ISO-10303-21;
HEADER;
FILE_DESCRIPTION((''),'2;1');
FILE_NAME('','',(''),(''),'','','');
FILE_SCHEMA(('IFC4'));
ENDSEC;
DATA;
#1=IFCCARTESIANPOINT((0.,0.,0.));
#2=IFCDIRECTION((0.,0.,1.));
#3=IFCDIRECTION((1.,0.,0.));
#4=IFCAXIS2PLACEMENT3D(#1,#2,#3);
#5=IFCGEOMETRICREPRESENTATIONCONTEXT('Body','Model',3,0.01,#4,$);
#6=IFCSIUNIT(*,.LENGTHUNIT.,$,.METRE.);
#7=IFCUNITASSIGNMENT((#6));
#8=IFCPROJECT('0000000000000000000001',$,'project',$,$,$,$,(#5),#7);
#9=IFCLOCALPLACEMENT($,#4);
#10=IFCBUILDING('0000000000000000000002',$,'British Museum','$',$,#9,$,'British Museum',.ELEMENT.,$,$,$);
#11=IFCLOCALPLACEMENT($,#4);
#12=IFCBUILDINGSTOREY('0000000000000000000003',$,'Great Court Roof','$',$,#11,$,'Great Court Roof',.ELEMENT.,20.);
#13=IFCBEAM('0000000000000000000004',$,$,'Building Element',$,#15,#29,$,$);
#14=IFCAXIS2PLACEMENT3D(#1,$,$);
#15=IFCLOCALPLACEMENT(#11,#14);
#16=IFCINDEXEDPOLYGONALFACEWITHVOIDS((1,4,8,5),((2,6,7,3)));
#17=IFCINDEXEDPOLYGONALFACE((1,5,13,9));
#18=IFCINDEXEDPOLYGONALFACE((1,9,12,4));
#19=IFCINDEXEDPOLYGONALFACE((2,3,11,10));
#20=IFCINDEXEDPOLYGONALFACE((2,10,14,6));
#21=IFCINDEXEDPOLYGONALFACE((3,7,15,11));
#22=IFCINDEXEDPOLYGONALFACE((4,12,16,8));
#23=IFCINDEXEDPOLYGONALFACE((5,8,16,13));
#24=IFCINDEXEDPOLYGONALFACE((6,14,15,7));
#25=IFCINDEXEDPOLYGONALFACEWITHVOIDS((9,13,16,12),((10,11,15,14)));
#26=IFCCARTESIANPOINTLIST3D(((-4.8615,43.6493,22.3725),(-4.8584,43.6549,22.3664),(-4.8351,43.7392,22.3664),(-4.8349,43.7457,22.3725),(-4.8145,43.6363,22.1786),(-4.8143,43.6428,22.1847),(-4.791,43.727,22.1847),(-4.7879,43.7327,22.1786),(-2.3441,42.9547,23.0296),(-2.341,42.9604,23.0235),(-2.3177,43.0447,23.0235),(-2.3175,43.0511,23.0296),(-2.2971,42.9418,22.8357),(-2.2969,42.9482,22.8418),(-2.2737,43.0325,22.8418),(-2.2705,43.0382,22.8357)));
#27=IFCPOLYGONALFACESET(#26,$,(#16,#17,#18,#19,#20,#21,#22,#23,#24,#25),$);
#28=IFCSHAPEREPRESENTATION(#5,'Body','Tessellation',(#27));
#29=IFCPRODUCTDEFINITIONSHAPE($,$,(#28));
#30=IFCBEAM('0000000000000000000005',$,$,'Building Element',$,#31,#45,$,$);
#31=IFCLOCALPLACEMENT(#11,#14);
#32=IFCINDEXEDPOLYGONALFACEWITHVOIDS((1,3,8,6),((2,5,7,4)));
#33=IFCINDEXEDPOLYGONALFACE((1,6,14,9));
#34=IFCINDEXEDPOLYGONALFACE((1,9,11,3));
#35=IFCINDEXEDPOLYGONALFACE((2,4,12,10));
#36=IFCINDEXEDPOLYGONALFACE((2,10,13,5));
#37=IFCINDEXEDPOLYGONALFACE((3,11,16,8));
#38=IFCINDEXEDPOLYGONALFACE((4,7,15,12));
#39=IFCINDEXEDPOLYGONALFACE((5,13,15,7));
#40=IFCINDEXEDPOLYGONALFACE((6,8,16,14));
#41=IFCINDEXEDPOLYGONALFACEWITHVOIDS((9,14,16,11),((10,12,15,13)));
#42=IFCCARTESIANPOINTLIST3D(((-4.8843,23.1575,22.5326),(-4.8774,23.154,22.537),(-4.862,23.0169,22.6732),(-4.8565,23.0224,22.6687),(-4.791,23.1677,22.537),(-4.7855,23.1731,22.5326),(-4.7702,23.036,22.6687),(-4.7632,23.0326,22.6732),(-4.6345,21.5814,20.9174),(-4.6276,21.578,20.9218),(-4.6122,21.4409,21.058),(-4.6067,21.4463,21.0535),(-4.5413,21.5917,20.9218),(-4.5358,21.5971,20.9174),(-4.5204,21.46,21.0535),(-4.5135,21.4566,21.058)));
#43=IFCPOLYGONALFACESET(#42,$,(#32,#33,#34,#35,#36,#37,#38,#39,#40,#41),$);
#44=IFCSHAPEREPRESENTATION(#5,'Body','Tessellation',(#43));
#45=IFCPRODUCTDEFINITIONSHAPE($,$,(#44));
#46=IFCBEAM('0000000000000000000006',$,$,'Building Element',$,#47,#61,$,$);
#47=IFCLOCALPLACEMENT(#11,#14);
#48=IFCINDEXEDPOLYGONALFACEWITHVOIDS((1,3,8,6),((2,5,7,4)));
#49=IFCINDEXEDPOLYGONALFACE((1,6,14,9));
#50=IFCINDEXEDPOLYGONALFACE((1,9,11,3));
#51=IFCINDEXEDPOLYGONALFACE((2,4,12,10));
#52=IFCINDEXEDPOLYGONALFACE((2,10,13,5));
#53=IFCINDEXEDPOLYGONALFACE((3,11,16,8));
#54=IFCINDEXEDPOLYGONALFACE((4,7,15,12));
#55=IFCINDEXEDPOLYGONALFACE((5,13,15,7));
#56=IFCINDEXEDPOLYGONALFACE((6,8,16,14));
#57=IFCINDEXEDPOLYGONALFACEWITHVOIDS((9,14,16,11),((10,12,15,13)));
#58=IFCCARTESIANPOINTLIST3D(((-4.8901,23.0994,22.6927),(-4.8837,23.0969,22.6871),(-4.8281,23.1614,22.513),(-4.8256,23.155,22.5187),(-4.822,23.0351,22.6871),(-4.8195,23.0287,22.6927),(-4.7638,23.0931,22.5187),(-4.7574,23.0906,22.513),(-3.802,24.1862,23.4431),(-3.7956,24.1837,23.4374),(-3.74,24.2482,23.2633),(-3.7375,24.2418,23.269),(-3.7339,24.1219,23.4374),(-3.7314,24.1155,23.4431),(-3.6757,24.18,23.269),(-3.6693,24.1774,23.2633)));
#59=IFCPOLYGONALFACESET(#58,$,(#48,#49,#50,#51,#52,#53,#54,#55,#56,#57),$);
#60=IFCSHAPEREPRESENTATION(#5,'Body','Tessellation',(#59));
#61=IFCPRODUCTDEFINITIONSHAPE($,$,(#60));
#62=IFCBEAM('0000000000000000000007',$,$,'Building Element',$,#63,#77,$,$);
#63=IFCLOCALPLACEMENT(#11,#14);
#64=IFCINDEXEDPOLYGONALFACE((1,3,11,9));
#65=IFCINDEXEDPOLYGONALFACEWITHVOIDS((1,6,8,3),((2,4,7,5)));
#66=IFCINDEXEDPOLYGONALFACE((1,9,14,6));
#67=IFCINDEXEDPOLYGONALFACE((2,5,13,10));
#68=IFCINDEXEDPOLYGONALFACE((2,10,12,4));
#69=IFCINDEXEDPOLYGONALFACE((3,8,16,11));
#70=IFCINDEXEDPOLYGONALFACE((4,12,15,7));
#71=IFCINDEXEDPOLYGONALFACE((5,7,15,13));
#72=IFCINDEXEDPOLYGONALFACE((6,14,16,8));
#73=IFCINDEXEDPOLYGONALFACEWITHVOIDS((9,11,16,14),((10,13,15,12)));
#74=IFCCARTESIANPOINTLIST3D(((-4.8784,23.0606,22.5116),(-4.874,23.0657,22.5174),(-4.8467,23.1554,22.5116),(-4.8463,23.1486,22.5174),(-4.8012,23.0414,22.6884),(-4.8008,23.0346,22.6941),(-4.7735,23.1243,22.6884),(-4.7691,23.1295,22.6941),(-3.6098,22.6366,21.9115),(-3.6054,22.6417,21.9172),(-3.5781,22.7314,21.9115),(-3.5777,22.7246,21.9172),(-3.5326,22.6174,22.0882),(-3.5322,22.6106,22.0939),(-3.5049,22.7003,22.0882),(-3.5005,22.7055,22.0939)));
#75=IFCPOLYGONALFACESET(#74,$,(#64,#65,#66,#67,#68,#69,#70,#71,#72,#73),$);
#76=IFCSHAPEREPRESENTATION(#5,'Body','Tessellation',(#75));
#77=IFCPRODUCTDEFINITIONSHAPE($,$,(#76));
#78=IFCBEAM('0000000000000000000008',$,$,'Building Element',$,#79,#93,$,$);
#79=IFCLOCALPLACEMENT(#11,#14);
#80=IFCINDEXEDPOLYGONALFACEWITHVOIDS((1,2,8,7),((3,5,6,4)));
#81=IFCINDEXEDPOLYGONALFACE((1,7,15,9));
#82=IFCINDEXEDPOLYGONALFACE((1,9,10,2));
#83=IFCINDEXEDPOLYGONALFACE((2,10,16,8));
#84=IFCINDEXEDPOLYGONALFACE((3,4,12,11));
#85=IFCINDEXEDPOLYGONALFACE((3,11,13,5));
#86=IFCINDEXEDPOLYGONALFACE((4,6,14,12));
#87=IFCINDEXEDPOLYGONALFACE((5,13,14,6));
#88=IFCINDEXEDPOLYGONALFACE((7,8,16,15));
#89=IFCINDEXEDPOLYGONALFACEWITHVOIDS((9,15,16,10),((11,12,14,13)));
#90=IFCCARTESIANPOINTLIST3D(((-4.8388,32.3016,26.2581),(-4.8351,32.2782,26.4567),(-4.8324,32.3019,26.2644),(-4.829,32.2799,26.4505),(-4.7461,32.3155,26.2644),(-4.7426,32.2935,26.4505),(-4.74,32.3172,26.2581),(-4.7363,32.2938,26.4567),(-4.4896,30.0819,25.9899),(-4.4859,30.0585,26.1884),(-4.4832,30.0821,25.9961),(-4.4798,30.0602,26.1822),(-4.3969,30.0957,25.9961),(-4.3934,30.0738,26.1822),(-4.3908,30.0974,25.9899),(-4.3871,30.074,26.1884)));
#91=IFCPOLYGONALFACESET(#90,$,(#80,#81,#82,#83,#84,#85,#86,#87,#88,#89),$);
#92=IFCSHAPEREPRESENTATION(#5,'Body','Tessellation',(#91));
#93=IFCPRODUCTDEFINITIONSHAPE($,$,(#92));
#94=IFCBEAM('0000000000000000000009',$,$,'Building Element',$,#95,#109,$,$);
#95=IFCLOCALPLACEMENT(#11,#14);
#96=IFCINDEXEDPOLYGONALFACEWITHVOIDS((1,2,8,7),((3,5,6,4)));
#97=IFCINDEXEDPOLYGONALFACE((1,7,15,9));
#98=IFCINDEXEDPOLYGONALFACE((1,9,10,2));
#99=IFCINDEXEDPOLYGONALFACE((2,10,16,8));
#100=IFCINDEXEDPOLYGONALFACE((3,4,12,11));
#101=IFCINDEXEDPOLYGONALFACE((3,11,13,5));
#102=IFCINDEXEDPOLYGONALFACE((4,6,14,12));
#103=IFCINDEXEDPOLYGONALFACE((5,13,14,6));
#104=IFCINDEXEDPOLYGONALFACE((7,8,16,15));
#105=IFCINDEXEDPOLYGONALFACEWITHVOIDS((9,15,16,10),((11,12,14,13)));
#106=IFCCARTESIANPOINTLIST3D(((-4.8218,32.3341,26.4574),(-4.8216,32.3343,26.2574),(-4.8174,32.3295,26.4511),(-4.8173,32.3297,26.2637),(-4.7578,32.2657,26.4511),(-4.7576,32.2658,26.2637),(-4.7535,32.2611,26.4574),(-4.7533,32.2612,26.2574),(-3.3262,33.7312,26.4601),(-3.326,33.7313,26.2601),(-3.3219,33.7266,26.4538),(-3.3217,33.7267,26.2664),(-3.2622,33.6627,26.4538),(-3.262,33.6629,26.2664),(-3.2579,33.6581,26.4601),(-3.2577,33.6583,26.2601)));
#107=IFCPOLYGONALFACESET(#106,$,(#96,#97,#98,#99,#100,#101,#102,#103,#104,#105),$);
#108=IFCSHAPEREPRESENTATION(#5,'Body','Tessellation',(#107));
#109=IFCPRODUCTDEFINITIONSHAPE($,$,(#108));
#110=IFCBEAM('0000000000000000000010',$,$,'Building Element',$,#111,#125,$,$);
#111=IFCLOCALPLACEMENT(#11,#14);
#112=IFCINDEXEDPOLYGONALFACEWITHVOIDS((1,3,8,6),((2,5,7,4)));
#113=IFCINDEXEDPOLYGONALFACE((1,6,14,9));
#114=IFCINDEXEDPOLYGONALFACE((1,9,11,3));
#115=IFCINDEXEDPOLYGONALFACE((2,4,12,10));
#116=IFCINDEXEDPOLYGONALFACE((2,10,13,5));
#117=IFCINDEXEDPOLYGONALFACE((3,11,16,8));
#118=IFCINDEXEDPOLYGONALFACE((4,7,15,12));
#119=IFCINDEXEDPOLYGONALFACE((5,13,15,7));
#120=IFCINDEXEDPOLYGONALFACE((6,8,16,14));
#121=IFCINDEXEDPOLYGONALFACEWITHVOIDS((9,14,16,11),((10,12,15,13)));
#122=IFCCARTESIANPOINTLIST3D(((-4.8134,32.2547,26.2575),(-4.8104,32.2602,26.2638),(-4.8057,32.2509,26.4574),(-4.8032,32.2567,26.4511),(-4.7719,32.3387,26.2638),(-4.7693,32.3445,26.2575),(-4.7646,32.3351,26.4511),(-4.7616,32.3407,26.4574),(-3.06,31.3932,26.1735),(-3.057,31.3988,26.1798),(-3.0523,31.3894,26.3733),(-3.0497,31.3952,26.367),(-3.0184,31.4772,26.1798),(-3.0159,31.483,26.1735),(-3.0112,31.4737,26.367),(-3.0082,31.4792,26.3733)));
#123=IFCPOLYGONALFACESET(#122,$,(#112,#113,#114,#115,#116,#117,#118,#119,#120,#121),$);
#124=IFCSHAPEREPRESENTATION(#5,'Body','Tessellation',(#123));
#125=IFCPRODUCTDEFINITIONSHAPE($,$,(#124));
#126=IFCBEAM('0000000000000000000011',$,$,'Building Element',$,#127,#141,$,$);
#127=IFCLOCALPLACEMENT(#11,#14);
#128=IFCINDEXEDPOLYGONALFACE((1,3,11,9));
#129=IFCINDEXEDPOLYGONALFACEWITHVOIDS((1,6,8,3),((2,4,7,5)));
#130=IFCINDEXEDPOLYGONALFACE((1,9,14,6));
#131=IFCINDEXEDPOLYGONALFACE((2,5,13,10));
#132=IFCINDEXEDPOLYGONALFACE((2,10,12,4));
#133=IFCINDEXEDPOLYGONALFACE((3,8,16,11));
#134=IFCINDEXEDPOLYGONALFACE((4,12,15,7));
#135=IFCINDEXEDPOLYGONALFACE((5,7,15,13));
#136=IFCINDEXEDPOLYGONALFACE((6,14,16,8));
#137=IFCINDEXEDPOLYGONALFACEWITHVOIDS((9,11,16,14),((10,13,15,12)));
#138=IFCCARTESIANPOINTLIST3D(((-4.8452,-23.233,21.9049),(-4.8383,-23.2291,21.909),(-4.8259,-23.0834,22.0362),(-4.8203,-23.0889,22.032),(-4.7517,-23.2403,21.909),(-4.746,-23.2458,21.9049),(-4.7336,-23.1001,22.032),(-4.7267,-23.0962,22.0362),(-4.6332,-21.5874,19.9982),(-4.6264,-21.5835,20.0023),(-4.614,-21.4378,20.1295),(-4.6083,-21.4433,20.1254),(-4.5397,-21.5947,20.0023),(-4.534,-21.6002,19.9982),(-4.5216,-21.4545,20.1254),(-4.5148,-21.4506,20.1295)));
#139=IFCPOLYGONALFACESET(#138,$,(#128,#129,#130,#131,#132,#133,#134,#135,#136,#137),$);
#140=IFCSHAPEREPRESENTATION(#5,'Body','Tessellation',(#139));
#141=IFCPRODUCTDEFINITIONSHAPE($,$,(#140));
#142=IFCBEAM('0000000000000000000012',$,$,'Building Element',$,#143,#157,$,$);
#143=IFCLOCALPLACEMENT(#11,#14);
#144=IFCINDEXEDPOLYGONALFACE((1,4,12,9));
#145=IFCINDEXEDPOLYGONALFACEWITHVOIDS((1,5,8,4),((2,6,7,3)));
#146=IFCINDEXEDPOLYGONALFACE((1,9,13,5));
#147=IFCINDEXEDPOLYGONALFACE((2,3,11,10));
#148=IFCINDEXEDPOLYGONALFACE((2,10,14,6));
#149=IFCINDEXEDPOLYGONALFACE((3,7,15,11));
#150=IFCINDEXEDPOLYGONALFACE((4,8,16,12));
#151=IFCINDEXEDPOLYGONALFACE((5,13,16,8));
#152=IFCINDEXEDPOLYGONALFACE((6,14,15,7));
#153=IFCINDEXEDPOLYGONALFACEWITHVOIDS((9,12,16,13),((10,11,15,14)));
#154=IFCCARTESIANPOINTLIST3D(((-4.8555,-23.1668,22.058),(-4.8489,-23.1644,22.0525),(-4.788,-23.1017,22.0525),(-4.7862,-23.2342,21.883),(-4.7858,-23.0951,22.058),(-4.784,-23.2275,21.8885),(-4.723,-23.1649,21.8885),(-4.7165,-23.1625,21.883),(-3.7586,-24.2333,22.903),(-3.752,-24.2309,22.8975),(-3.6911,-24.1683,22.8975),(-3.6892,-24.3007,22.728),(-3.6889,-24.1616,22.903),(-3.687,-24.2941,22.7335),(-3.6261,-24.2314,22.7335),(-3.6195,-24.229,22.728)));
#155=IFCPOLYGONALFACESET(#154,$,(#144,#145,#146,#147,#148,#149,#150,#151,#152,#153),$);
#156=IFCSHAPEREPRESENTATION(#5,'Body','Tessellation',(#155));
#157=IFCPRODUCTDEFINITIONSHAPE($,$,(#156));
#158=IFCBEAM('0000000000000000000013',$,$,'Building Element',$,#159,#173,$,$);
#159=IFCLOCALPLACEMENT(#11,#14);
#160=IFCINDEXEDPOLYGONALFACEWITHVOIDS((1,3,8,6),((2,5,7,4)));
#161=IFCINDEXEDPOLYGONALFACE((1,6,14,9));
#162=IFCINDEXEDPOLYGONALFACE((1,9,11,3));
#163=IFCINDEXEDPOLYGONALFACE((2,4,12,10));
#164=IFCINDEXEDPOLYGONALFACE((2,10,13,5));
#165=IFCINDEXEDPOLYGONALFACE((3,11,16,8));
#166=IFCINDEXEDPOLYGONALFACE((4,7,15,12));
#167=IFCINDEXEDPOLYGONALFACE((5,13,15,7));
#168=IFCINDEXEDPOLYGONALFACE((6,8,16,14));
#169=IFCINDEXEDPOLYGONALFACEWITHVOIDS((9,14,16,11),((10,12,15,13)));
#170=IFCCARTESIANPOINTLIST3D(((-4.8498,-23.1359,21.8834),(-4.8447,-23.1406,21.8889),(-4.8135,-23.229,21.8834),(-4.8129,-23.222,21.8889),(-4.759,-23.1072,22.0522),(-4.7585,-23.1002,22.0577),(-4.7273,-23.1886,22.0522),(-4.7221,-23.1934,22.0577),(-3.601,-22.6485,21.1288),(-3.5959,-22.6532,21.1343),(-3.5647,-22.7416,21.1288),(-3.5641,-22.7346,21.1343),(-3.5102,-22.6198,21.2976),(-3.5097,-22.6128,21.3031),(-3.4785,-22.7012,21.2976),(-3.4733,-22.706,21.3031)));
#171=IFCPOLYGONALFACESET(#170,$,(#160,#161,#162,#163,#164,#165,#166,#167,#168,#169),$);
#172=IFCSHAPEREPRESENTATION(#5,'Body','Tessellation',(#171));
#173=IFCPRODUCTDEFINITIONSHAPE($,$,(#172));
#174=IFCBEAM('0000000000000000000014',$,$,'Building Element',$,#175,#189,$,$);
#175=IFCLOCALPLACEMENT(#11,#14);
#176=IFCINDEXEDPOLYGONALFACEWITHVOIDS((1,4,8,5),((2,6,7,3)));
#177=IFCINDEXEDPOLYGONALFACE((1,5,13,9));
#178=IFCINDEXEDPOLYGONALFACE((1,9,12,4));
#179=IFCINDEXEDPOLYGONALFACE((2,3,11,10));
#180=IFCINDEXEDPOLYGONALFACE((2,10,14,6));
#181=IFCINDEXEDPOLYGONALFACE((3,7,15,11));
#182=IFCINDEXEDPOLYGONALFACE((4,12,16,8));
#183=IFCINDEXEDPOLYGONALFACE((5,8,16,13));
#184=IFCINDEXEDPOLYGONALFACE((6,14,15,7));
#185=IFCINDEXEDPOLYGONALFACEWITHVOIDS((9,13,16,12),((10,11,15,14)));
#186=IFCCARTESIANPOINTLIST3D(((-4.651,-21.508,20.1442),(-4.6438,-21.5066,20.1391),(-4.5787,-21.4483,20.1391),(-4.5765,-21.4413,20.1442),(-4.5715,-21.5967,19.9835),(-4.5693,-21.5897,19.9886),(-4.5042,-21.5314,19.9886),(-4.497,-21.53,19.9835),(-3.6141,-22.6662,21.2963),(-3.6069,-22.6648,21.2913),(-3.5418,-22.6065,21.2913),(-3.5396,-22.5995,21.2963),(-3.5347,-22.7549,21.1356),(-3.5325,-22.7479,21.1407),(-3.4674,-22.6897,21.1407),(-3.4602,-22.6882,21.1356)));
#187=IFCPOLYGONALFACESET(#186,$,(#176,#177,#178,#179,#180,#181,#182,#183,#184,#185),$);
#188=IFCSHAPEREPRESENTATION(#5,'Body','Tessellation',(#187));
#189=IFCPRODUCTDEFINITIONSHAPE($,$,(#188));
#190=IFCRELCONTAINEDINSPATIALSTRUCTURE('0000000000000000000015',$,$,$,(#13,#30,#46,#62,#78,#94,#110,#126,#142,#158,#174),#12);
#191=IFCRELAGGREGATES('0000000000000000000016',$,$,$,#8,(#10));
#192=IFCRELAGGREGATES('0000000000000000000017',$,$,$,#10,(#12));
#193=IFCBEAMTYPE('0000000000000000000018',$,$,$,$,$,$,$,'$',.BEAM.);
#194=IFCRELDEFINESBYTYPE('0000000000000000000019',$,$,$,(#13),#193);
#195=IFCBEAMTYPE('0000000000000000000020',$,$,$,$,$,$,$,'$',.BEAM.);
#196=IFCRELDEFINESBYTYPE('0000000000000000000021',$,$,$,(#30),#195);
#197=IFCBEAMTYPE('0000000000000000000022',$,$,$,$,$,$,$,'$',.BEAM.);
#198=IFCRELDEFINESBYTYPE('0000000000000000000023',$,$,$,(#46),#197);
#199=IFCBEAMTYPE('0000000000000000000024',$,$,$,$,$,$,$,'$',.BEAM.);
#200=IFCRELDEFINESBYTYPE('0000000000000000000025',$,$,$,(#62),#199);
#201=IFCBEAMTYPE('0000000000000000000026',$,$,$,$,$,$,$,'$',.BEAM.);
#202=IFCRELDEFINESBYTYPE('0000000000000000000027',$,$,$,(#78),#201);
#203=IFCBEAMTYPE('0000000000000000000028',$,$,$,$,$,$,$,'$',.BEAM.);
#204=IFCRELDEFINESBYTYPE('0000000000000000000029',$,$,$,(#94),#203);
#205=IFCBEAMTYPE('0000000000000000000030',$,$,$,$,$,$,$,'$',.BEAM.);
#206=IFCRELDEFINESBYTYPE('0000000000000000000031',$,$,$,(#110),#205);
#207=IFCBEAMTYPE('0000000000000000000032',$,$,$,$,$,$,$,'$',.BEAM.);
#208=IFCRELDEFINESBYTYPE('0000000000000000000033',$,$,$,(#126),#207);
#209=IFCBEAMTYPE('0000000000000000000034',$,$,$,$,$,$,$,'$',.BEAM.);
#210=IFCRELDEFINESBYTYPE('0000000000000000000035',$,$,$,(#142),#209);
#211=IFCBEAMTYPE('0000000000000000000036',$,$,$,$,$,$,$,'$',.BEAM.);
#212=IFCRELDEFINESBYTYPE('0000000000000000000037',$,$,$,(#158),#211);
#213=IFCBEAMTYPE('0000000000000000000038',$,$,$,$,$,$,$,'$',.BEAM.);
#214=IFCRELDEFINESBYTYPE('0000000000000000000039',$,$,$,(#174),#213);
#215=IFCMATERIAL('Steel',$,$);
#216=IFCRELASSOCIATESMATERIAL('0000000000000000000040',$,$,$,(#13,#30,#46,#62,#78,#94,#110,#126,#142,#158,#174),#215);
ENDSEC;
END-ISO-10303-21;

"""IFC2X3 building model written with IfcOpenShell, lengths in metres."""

from ifc_helpers import new_model, si_unit, frame, origin_with_axes, origin_2d, place, context, project, spatial, hollow_rectangle, extrude, material, type_object, element, save


model = new_model("IFC2X3")

# Units and contexts
model_context = context("Model", 3, precision=0.01, world=origin_with_axes(), identifier="Body")
ifc_project = project(units=[si_unit("LENGTHUNIT", "METRE")], contexts=[model_context])

# Building, storey
building_placement = place(None, origin_with_axes())
building = spatial("IfcBuilding", under=ifc_project, at=building_placement, Name="British Museum", Description="$", LongName="British Museum", CompositionType="ELEMENT")
storey_placement = place(None, origin_with_axes())
storey = spatial("IfcBuildingStorey", under=building, at=storey_placement, Name="Great Court Roof", Description="$", LongName="Great Court Roof", CompositionType="ELEMENT", Elevation=20.0)

# Beams
ifc_material = material(Name="Steel")
beam_type_1 = type_object("IfcBeamType", ElementType="$", PredefinedType="BEAM")
beam_1_placement = place(None, origin_with_axes())
element("IfcBeam", 1, at=beam_1_placement, inside=storey, type_object=beam_type_1, material=ifc_material, Description="Building Element", context=model_context, shape_type="SweptSolid", body=[
    extrude(hollow_rectangle(XDim=0.1, YDim=0.2, WallThickness=0.0063, InnerFilletRadius=-0.0063, OuterFilletRadius=0.0, at=origin_2d()), frame((-4.8247, 43.691, 22.2755), z_axis=(0.934845, -0.257913, 0.244021), x_axis=(0.265953, 0.963986, 0.0)), (0.0, 0.0, 1.0), 2.6928),
])
beam_type_2 = type_object("IfcBeamType", ElementType="$", PredefinedType="BEAM")
beam_2_placement = place(None, origin_with_axes())
element("IfcBeam", 2, at=beam_2_placement, inside=storey, type_object=beam_type_2, material=ifc_material, Description="Building Element", context=model_context, shape_type="SweptSolid", body=[
    extrude(hollow_rectangle(XDim=0.1, YDim=0.2, WallThickness=0.0063, InnerFilletRadius=-0.0063, OuterFilletRadius=0.0, at=origin_2d()), frame((-4.8238, 23.095, 22.6029), z_axis=(0.110005, -0.694141, -0.711384), x_axis=(0.987674, 0.156523, 0.0)), (0.0, 0.0, 1.0), 2.2705),
])
beam_type_3 = type_object("IfcBeamType", ElementType="$", PredefinedType="BEAM")
beam_3_placement = place(None, origin_with_axes())
element("IfcBeam", 3, at=beam_3_placement, inside=storey, type_object=beam_type_3, material=ifc_material, Description="Building Element", context=model_context, shape_type="SweptSolid", body=[
    extrude(hollow_rectangle(XDim=0.1, YDim=0.2, WallThickness=0.0063, InnerFilletRadius=-0.0063, OuterFilletRadius=0.0, at=origin_2d()), frame((-4.8238, 23.095, 22.6029), z_axis=(0.635872, 0.635132, 0.438491), x_axis=(-0.706695, 0.707519, 0.0)), (0.0, 0.0, 1.0), 1.7112),
])
beam_type_4 = type_object("IfcBeamType", ElementType="$", PredefinedType="BEAM")
beam_4_placement = place(None, origin_with_axes())
element("IfcBeam", 4, at=beam_4_placement, inside=storey, type_object=beam_type_4, material=ifc_material, Description="Building Element", context=model_context, shape_type="SweptSolid", body=[
    extrude(hollow_rectangle(XDim=0.1, YDim=0.2, WallThickness=0.0063, InnerFilletRadius=-0.0063, OuterFilletRadius=0.0, at=origin_2d()), frame((-4.8238, 23.095, 22.6029), z_axis=(0.86531, -0.289209, -0.409386), x_axis=(0.316989, 0.948429, 0.0)), (0.0, 0.0, 1.0), 1.4661),
])
beam_type_5 = type_object("IfcBeamType", ElementType="$", PredefinedType="BEAM")
beam_5_placement = place(None, origin_with_axes())
element("IfcBeam", 5, at=beam_5_placement, inside=storey, type_object=beam_type_5, material=ifc_material, Description="Building Element", context=model_context, shape_type="SweptSolid", body=[
    extrude(hollow_rectangle(XDim=0.1, YDim=0.2, WallThickness=0.0063, InnerFilletRadius=-0.0063, OuterFilletRadius=0.0, at=origin_2d()), frame((-4.7875, 32.2977, 26.3574), z_axis=(0.154304, -0.980885, -0.118556), x_axis=(0.987852, 0.1554, 0.0)), (0.0, 0.0, 1.0), 2.263),
])
beam_type_6 = type_object("IfcBeamType", ElementType="$", PredefinedType="BEAM")
beam_6_placement = place(None, origin_with_axes())
element("IfcBeam", 6, at=beam_6_placement, inside=storey, type_object=beam_type_6, material=ifc_material, Description="Building Element", context=model_context, shape_type="SweptSolid", body=[
    extrude(hollow_rectangle(XDim=0.1, YDim=0.2, WallThickness=0.0063, InnerFilletRadius=-0.0063, OuterFilletRadius=0.0, at=origin_2d()), frame((-4.7875, 32.2977, 26.3574), z_axis=(0.730772, 0.682621, 0.001315), x_axis=(-0.682621, 0.730772, 0.0)), (0.0, 0.0, 1.0), 2.0466),
])
beam_type_7 = type_object("IfcBeamType", ElementType="$", PredefinedType="BEAM")
beam_7_placement = place(None, origin_with_axes())
element("IfcBeam", 7, at=beam_7_placement, inside=storey, type_object=beam_type_7, material=ifc_material, Description="Building Element", context=model_context, shape_type="SweptSolid", body=[
    extrude(hollow_rectangle(XDim=0.1, YDim=0.2, WallThickness=0.0063, InnerFilletRadius=-0.0063, OuterFilletRadius=0.0, at=origin_2d()), frame((-4.7875, 32.2977, 26.3574), z_axis=(0.896695, -0.440557, -0.042977), x_axis=(0.440965, 0.897524, 0.0)), (0.0, 0.0, 1.0), 1.9555),
])
beam_type_8 = type_object("IfcBeamType", ElementType="$", PredefinedType="BEAM")
beam_8_placement = place(None, origin_with_axes())
element("IfcBeam", 8, at=beam_8_placement, inside=storey, type_object=beam_type_8, material=ifc_material, Description="Building Element", context=model_context, shape_type="SweptSolid", body=[
    extrude(hollow_rectangle(XDim=0.1, YDim=0.2, WallThickness=0.0063, InnerFilletRadius=-0.0063, OuterFilletRadius=0.0, at=origin_2d()), frame((-4.786, -23.1646, 21.9705), z_axis=(0.083867, 0.65108, -0.754362), x_axis=(-0.991806, 0.127756, 0.0)), (0.0, 0.0, 1.0), 2.5275),
])
beam_type_9 = type_object("IfcBeamType", ElementType="$", PredefinedType="BEAM")
beam_9_placement = place(None, origin_with_axes())
element("IfcBeam", 9, at=beam_9_placement, inside=storey, type_object=beam_type_9, material=ifc_material, Description="Building Element", context=model_context, shape_type="SweptSolid", body=[
    extrude(hollow_rectangle(XDim=0.1, YDim=0.2, WallThickness=0.0063, InnerFilletRadius=-0.0063, OuterFilletRadius=0.0, at=origin_2d()), frame((-4.786, -23.1646, 21.9705), z_axis=(0.627606, -0.61023, 0.483457), x_axis=(0.697112, 0.716962, 0.0)), (0.0, 0.0, 1.0), 1.7478),
])
beam_type_10 = type_object("IfcBeamType", ElementType="$", PredefinedType="BEAM")
beam_10_placement = place(None, origin_with_axes())
element("IfcBeam", 10, at=beam_10_placement, inside=storey, type_object=beam_type_10, material=ifc_material, Description="Building Element", context=model_context, shape_type="SweptSolid", body=[
    extrude(hollow_rectangle(XDim=0.1, YDim=0.2, WallThickness=0.0063, InnerFilletRadius=-0.0063, OuterFilletRadius=0.0, at=origin_2d()), frame((-4.786, -23.1646, 21.9705), z_axis=(0.811807, 0.316837, -0.490493), x_axis=(-0.363576, 0.931564, 0.0)), (0.0, 0.0, 1.0), 1.5383),
])
beam_type_11 = type_object("IfcBeamType", ElementType="$", PredefinedType="BEAM")
beam_11_placement = place(None, origin_with_axes())
element("IfcBeam", 11, at=beam_11_placement, inside=storey, type_object=beam_type_11, material=ifc_material, Description="Building Element", context=model_context, shape_type="SweptSolid", body=[
    extrude(hollow_rectangle(XDim=0.1, YDim=0.2, WallThickness=0.0063, InnerFilletRadius=-0.0063, OuterFilletRadius=0.0, at=origin_2d()), frame((-4.574, -21.519, 20.0638), z_axis=(0.53585, -0.59859, 0.595445), x_axis=(0.745075, 0.666981, 0.0)), (0.0, 0.0, 1.0), 1.9349),
])

save(model, "model.ifc")
